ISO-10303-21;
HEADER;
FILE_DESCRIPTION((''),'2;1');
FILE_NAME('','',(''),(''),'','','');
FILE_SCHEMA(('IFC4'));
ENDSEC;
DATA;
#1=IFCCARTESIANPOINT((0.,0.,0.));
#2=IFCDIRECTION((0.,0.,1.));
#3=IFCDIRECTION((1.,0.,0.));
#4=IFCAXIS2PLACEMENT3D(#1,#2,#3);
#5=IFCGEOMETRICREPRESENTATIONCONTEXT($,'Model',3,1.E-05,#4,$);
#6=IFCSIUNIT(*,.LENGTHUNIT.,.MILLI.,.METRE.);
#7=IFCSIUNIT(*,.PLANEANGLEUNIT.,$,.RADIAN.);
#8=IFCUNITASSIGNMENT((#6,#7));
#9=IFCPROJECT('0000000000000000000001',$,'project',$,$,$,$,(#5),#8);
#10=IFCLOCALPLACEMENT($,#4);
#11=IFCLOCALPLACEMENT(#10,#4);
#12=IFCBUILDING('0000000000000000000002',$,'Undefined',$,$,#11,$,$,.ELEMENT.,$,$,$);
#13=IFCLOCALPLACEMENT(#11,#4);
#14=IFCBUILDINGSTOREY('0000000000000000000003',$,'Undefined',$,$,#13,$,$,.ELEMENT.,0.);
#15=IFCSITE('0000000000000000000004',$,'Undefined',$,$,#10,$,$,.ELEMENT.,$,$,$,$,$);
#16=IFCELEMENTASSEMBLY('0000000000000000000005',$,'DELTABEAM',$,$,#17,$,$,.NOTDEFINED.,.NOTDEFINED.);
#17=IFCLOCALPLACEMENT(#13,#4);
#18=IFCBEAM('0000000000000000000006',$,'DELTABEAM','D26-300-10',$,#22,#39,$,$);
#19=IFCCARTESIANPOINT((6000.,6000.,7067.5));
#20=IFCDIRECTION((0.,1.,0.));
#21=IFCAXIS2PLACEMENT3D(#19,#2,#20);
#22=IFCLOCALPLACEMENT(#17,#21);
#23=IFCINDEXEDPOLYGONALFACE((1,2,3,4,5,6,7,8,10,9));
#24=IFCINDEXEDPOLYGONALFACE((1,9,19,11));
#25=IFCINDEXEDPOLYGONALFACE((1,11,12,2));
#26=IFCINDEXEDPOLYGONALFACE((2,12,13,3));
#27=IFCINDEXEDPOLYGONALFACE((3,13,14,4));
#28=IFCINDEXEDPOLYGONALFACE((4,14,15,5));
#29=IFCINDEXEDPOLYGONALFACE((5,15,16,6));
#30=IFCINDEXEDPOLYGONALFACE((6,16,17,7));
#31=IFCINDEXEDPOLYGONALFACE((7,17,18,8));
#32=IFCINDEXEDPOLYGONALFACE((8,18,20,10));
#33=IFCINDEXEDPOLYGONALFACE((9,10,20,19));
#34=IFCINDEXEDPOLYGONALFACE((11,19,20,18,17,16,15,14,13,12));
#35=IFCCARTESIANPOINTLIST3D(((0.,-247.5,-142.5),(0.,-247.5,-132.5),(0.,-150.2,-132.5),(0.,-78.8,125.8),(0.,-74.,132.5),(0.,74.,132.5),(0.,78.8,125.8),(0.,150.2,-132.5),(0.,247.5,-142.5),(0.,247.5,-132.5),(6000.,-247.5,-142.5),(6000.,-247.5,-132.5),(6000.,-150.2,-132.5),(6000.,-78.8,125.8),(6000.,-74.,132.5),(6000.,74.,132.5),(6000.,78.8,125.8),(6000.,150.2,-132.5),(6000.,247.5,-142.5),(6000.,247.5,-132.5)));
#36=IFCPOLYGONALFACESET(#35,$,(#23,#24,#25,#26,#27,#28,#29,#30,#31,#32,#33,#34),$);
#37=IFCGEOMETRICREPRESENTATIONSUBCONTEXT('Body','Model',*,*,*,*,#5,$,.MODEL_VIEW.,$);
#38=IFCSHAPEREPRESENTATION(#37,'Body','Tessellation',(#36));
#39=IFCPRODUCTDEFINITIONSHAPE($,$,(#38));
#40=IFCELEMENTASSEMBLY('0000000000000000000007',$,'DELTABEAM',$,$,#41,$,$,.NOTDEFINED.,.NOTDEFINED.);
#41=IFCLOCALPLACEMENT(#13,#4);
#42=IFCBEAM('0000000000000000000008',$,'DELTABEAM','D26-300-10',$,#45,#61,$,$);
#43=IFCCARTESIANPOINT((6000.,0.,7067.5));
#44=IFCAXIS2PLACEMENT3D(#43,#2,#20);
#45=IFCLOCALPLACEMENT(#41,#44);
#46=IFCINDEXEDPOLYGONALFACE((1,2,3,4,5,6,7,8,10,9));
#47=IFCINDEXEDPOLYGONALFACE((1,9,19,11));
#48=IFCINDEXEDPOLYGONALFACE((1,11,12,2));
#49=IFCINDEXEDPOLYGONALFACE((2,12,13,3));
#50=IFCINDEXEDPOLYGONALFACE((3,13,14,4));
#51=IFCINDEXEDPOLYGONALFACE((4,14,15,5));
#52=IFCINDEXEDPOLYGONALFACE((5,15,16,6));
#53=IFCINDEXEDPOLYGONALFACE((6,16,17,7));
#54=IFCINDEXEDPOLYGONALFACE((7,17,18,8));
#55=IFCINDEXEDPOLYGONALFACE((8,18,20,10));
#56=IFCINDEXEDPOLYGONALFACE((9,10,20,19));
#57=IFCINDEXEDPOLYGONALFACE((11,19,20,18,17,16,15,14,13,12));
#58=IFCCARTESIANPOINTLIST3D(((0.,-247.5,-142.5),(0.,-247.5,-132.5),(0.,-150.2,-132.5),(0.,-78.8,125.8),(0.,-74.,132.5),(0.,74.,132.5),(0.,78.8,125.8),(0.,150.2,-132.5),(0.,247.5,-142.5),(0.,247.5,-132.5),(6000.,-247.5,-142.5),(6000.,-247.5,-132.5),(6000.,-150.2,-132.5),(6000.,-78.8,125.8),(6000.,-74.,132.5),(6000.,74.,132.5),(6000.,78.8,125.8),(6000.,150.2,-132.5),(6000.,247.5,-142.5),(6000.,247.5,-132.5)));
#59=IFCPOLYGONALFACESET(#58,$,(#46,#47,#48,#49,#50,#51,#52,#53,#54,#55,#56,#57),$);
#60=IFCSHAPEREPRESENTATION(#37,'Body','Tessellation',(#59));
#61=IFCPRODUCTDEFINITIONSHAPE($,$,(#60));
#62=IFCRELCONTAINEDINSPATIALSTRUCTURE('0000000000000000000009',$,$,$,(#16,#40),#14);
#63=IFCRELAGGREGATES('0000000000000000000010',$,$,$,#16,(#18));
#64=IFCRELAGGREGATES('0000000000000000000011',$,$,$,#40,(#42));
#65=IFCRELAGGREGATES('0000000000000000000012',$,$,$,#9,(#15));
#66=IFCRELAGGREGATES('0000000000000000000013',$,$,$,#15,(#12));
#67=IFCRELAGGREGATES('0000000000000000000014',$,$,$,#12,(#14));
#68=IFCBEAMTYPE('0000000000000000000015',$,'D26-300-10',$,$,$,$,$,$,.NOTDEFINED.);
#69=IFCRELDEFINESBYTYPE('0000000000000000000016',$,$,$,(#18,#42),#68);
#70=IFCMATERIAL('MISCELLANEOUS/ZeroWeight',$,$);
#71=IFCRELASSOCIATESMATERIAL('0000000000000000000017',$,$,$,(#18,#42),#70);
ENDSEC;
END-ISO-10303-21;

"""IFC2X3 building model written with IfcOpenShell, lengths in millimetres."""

from ifc_helpers import new_model, si_unit, frame, origin_with_axes, place, context, subcontext, project, spatial, polyline, outline, extrude, material, type_object, element, aggregate, save


model = new_model("IFC2X3")

# Units and contexts
model_context = context("Model", 3, precision=1e-05, world=origin_with_axes())
body_context = subcontext(model_context, "Body", "Model", "MODEL_VIEW")
ifc_project = project(units=[si_unit("LENGTHUNIT", "METRE", prefix="MILLI"), si_unit("PLANEANGLEUNIT", "RADIAN")], contexts=[model_context])

# Site, building, storey
site_placement = place(None, origin_with_axes())
site = spatial("IfcSite", under=ifc_project, at=site_placement, Name="Undefined", CompositionType="ELEMENT")
building_placement = place(site_placement, origin_with_axes())
building = spatial("IfcBuilding", under=site, at=building_placement, Name="Undefined", CompositionType="ELEMENT")
storey_placement = place(building_placement, origin_with_axes())
storey = spatial("IfcBuildingStorey", under=building, at=storey_placement, Name="Undefined", CompositionType="ELEMENT", Elevation=0.0)

# Element assemblies, beams
ifc_material_1 = material(Name="MISCELLANEOUS/ZeroWeight")
assembly_1_placement = place(storey_placement, origin_with_axes())
assembly_1 = element("IfcElementAssembly", 1, at=assembly_1_placement, inside=storey, Name="DELTABEAM", AssemblyPlace="NOTDEFINED", PredefinedType="NOTDEFINED")
beam_type_1 = type_object("IfcBeamType", Name="D26-300-10", PredefinedType="NOTDEFINED")
beam_1_placement = place(assembly_1_placement, frame((6000.0, 6000.0, 7067.5), z_axis=(0.0, 0.0, 1.0), x_axis=(0.0, 1.0, 0.0)))
beam_1 = element("IfcBeam", 2, at=beam_1_placement, type_object=beam_type_1, material=ifc_material_1, Name="DELTABEAM", Description="D26-300-10", context=body_context, shape_type="SweptSolid", body=[
    extrude(outline(polyline([(-75.1, 120.5), (-145.0, -132.5), (247.5, -132.5), (247.5, -142.5), (-247.5, -142.5), (-247.5, -132.5), (-150.2, -132.5), (-78.8, 125.8), (-74.0, 132.5), (74.0, 132.5), (78.8, 125.8), (150.2, -132.5), (145.0, -132.5), (75.1, 120.5), (-75.1, 120.5)])), frame((6000.0, 0.0, 0.0), z_axis=(-1.0, 0.0, 0.0), x_axis=(0.0, -1.0, 0.0)), (0.0, 0.0, 1.0), 6000.0),
])
aggregate(assembly_1, [beam_1])
assembly_2_placement = place(storey_placement, origin_with_axes())
assembly_2 = element("IfcElementAssembly", 3, at=assembly_2_placement, inside=storey, Name="DELTABEAM", AssemblyPlace="NOTDEFINED", PredefinedType="NOTDEFINED")
beam_2_placement = place(assembly_2_placement, frame((6000.0, 0.0, 7067.5), z_axis=(0.0, 0.0, 1.0), x_axis=(0.0, 1.0, 0.0)))
beam_2 = element("IfcBeam", 4, at=beam_2_placement, type_object=beam_type_1, material=ifc_material_1, Name="DELTABEAM", Description="D26-300-10", context=body_context, shape_type="SweptSolid", body=[
    extrude(outline(polyline([(-75.1, 120.5), (-145.0, -132.5), (247.5, -132.5), (247.5, -142.5), (-247.5, -142.5), (-247.5, -132.5), (-150.2, -132.5), (-78.8, 125.8), (-74.0, 132.5), (74.0, 132.5), (78.8, 125.8), (150.2, -132.5), (145.0, -132.5), (75.1, 120.5), (-75.1, 120.5)])), frame((6000.0, 0.0, 0.0), z_axis=(-1.0, 0.0, 0.0), x_axis=(0.0, -1.0, 0.0)), (0.0, 0.0, 1.0), 6000.0),
])
aggregate(assembly_2, [beam_2])

save(model, "model.ifc")
